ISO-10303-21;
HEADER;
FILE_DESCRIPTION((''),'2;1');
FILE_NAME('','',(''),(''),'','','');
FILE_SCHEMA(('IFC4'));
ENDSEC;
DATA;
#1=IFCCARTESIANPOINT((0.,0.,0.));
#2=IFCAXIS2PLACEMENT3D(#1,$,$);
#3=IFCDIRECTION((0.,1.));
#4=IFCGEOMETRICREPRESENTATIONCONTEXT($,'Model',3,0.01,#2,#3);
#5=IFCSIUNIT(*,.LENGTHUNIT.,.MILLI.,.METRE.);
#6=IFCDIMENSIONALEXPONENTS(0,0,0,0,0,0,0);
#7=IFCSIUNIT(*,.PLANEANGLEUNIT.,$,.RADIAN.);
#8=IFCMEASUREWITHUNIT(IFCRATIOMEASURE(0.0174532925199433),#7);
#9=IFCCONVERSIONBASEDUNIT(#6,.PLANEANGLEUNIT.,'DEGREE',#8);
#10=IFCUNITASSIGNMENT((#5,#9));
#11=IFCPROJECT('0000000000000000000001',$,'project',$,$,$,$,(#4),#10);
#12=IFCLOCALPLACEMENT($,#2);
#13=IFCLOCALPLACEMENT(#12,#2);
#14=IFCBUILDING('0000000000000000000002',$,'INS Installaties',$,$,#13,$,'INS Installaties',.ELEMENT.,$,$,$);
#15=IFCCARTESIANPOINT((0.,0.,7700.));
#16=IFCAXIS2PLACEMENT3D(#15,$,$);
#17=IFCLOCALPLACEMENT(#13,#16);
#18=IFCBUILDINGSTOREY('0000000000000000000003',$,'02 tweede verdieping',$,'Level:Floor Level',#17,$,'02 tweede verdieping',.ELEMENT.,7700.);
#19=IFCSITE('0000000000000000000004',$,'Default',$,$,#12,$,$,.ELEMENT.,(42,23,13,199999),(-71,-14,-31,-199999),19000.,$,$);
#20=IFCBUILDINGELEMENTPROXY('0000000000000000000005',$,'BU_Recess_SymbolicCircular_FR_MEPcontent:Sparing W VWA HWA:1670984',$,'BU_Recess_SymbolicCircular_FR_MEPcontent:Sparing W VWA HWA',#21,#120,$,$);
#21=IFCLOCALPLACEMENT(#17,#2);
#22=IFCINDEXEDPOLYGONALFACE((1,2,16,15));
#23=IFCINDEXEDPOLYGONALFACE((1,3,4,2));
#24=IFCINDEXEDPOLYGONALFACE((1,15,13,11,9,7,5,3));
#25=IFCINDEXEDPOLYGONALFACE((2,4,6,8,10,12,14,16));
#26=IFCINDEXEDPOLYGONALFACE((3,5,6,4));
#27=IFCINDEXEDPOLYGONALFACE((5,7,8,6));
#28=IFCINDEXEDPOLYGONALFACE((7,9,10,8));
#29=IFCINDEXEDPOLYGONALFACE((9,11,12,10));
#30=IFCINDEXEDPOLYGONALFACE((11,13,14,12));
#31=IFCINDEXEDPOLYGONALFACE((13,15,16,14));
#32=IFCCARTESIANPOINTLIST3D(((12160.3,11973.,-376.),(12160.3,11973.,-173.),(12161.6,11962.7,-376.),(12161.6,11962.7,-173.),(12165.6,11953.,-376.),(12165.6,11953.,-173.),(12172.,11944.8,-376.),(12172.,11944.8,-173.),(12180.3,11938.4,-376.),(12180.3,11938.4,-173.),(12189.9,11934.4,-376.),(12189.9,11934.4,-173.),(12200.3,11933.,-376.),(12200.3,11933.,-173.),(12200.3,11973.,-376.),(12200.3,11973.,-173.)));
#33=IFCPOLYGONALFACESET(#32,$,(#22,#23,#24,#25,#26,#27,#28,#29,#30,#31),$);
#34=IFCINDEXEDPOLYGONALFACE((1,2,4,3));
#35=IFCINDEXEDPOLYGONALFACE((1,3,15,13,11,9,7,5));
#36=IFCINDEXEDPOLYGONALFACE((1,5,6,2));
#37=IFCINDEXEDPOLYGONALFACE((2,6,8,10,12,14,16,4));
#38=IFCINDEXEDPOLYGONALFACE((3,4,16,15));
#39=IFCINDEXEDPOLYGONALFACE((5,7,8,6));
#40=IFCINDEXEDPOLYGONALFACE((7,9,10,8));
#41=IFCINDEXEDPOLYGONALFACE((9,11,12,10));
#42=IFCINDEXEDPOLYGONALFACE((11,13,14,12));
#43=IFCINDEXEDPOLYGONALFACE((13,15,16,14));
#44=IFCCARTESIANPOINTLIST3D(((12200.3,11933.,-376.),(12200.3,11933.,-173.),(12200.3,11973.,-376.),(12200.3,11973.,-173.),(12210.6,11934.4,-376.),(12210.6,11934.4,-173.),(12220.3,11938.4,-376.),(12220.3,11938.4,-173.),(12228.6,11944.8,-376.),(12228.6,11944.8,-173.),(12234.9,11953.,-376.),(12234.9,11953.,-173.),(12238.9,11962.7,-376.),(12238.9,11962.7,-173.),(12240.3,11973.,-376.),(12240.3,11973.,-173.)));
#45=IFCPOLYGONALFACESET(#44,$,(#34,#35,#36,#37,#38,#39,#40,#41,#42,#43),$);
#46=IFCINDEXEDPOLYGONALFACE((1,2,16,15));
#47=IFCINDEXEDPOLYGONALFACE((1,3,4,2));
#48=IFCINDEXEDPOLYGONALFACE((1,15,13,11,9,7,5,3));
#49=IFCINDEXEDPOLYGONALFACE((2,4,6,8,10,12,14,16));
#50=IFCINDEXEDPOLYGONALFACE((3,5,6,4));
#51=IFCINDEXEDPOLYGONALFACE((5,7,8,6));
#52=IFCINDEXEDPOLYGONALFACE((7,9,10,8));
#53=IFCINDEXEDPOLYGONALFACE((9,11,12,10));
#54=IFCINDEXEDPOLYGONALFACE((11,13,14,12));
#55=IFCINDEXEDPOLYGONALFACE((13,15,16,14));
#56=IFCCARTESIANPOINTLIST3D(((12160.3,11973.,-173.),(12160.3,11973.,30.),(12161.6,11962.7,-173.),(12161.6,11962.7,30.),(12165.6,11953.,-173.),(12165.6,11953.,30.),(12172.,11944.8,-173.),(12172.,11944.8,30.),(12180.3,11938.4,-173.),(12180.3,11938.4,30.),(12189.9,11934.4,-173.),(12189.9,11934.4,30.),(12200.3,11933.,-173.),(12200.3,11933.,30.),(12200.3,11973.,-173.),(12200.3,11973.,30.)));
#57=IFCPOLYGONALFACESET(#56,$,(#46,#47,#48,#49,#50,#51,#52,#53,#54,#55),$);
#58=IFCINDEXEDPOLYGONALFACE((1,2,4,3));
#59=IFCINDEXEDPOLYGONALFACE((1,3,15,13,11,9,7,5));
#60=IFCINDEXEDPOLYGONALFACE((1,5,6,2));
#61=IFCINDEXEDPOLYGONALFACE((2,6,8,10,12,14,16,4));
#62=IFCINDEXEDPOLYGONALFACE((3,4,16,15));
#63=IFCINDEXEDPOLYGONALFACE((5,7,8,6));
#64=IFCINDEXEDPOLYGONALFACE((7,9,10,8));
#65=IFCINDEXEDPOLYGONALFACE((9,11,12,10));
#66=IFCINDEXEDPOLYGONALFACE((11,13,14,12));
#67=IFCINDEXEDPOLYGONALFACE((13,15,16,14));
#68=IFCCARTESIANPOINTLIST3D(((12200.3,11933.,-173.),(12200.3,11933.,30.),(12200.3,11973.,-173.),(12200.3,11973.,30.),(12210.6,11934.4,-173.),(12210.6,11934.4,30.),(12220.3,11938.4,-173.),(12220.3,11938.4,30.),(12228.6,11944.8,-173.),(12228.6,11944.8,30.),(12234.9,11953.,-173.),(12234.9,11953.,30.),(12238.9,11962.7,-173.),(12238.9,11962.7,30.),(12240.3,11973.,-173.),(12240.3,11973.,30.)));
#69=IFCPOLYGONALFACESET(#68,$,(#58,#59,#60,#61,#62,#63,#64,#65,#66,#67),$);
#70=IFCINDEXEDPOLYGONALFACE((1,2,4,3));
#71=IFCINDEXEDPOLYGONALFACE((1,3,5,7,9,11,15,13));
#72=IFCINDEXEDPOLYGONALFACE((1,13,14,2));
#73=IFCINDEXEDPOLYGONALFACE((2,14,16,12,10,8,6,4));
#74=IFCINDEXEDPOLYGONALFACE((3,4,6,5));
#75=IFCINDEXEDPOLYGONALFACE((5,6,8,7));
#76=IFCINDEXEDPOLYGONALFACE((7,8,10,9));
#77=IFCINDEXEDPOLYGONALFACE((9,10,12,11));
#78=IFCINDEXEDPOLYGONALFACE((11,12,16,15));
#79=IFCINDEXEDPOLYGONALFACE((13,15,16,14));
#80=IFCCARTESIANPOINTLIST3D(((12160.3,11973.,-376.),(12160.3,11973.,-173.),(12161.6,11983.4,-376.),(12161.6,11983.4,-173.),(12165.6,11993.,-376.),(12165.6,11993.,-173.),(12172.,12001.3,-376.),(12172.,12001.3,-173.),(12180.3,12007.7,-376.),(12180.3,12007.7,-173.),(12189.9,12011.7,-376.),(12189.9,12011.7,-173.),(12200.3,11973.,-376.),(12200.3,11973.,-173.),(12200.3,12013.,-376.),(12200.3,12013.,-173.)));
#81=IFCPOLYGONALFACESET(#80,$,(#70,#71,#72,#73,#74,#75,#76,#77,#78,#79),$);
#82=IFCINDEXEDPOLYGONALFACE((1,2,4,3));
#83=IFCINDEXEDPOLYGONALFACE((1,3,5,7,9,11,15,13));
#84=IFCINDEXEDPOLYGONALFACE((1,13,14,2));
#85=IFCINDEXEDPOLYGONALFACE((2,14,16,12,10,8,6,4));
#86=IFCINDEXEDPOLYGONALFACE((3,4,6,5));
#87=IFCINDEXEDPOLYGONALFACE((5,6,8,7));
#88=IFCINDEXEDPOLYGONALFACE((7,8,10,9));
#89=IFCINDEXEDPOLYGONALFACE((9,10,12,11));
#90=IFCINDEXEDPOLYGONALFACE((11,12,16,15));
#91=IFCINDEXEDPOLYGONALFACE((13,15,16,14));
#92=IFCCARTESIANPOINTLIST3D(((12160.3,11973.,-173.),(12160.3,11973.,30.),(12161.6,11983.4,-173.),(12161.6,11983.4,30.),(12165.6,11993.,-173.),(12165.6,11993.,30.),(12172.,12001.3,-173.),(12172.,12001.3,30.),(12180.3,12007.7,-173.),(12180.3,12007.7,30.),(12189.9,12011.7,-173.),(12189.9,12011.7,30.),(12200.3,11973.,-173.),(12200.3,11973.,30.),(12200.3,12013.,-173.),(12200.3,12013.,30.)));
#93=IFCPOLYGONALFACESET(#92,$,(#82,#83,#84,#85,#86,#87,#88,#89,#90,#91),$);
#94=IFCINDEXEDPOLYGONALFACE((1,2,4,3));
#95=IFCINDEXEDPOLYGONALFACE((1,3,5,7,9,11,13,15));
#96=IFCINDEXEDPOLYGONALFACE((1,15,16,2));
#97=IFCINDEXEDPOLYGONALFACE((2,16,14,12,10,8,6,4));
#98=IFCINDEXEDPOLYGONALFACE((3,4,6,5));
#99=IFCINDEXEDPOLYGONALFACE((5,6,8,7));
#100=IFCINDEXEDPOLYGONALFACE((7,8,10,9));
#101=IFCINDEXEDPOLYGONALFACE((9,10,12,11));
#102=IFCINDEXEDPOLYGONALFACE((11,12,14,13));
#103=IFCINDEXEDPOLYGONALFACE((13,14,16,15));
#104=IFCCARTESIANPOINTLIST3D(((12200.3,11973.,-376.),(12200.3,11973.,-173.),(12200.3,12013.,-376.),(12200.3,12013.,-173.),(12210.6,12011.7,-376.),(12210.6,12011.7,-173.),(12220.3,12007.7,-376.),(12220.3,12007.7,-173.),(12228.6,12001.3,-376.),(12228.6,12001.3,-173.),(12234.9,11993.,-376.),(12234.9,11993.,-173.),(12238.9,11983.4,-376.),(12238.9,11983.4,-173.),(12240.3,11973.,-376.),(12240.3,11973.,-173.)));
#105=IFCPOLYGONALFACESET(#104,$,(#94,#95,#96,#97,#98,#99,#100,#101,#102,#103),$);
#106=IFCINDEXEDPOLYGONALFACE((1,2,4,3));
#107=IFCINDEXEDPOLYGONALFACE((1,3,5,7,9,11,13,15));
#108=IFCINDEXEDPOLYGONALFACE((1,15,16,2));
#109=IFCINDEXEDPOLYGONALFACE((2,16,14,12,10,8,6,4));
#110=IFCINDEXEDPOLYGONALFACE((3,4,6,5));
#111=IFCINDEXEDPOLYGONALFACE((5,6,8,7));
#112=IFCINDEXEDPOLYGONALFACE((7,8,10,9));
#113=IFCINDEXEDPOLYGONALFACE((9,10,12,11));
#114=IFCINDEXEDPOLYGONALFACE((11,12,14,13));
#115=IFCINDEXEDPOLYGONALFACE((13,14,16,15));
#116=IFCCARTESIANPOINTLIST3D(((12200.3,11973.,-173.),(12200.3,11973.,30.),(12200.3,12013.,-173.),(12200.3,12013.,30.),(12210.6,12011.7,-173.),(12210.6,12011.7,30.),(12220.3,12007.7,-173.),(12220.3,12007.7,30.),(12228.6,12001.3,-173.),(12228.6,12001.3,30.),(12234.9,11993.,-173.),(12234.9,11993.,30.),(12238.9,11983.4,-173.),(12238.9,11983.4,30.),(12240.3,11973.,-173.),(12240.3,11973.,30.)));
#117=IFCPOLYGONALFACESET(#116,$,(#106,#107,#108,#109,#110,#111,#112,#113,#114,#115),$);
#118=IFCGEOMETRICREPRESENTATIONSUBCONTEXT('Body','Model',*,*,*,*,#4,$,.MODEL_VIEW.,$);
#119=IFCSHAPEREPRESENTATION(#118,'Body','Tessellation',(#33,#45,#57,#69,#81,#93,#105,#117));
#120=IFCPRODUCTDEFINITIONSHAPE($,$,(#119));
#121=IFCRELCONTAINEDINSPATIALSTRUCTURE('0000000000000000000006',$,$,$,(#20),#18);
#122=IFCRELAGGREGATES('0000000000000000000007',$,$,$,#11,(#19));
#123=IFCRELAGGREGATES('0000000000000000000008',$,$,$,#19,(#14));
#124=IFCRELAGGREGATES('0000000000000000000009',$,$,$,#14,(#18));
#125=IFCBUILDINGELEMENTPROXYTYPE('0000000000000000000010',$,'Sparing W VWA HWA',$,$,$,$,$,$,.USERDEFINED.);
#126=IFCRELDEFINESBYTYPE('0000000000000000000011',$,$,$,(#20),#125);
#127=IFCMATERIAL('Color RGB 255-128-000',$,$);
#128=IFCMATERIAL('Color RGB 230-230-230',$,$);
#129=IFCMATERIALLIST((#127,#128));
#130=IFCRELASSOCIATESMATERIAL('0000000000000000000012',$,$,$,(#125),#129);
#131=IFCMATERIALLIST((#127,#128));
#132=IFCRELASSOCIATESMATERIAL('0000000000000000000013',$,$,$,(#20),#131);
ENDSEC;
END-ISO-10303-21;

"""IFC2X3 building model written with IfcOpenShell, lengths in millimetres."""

from ifc_helpers import new_model, entity, si_unit, converted_unit, direction, frame, frame_2d, origin, place, context, subcontext, project, spatial, polyline, circle_curve, parameter, trimmed, segment, composite_curve, outline, extrude, source, transform, mapped, material, material_list, type_object, type_shapes, element, save


model = new_model("IFC2X3")

# Units and contexts
model_context = context("Model", 3, precision=0.01, world=origin(), true_north=direction((0.0, 1.0)))
body_context = subcontext(model_context, "Body", "Model", "MODEL_VIEW")
ifc_project = project(units=[si_unit("LENGTHUNIT", "METRE", prefix="MILLI"), converted_unit("PLANEANGLEUNIT", "DEGREE", entity("IfcRatioMeasure", 0.0174532925199433), si_unit("PLANEANGLEUNIT", "RADIAN"), dimensions=[0, 0, 0, 0, 0, 0, 0])], contexts=[model_context])

# Site, building, storey
site_placement = place(None, origin())
site = spatial("IfcSite", under=ifc_project, at=site_placement, Name="Default", CompositionType="ELEMENT", RefLatitude=(42, 23, 13, 199999), RefLongitude=(-71, -14, -31, -199999), RefElevation=19000.0)
building_placement = place(site_placement, origin())
building = spatial("IfcBuilding", under=site, at=building_placement, Name="INS Installaties", LongName="INS Installaties", CompositionType="ELEMENT")
storey_placement = place(building_placement, frame((0.0, 0.0, 7700.0)))
storey = spatial("IfcBuildingStorey", under=building, at=storey_placement, Name="02 tweede verdieping", ObjectType="Level:Floor Level", LongName="02 tweede verdieping", CompositionType="ELEMENT", Elevation=7700.0)

# Building element proxy
ifc_material_1 = material(Name="Color RGB 255-128-000")
ifc_material_2 = material(Name="Color RGB 230-230-230")
ifc_material_list_1 = material_list([ifc_material_1, ifc_material_2])
building_element_proxy_type_1 = type_object("IfcBuildingElementProxyType", Name="Sparing W VWA HWA", PredefinedType="USERDEFINED", material=ifc_material_list_1)
shared_shape_1 = source(origin(), body_context, "Body", "SweptSolid", [
    extrude(outline(composite_curve([segment(trimmed(circle_curve(frame_2d((13.3, 13.3), x_axis=(1.0, 0.0)), 40.0), [parameter(180.0)], [parameter(270.0)], True, "PARAMETER"), True, "CONTINUOUS"), segment(polyline([(13.3, -26.7), (13.3, 13.3)]), True, "CONTINUOUS"), segment(polyline([(13.3, 13.3), (-26.7, 13.3)]), True, "CONTINUOUS")], self_intersect=False)), frame((13.3, 13.3, -403.0), z_axis=(0.0, 0.0, 1.0), x_axis=(-1.0, 0.0, 0.0)), (0.0, 0.0, 1.0), 203.0),
    extrude(outline(composite_curve([segment(polyline([(-26.7, -13.3), (13.3, -13.3)]), True, "CONTINUOUS"), segment(polyline([(13.3, -13.3), (13.3, 26.7)]), True, "CONTINUOUS"), segment(trimmed(circle_curve(frame_2d((13.3, -13.3), x_axis=(1.0, 0.0)), 40.0), [parameter(90.0)], [parameter(180.0)], True, "PARAMETER"), True, "CONTINUOUS")], self_intersect=False)), frame((-13.3, 13.3, -403.0)), (0.0, 0.0, 1.0), 203.0),
    extrude(outline(composite_curve([segment(trimmed(circle_curve(frame_2d((13.3, 13.3), x_axis=(1.0, 0.0)), 40.0), [parameter(180.0)], [parameter(270.0)], True, "PARAMETER"), True, "CONTINUOUS"), segment(polyline([(13.3, -26.7), (13.3, 13.3)]), True, "CONTINUOUS"), segment(polyline([(13.3, 13.3), (-26.7, 13.3)]), True, "CONTINUOUS")], self_intersect=False)), frame((13.3, 13.3, -200.0), z_axis=(0.0, 0.0, 1.0), x_axis=(-1.0, 0.0, 0.0)), (0.0, 0.0, 1.0), 203.0),
    extrude(outline(composite_curve([segment(polyline([(-26.7, -13.3), (13.3, -13.3)]), True, "CONTINUOUS"), segment(polyline([(13.3, -13.3), (13.3, 26.7)]), True, "CONTINUOUS"), segment(trimmed(circle_curve(frame_2d((13.3, -13.3), x_axis=(1.0, 0.0)), 40.0), [parameter(90.0)], [parameter(180.0)], True, "PARAMETER"), True, "CONTINUOUS")], self_intersect=False)), frame((-13.3, 13.3, -200.0)), (0.0, 0.0, 1.0), 203.0),
    extrude(outline(composite_curve([segment(polyline([(-26.7, -13.3), (13.3, -13.3)]), True, "CONTINUOUS"), segment(polyline([(13.3, -13.3), (13.3, 26.7)]), True, "CONTINUOUS"), segment(trimmed(circle_curve(frame_2d((13.3, -13.3), x_axis=(1.0, 0.0)), 40.0), [parameter(90.0)], [parameter(180.0)], True, "PARAMETER"), True, "CONTINUOUS")], self_intersect=False)), frame((13.3, -13.3, -403.0), z_axis=(0.0, 0.0, 1.0), x_axis=(-1.0, 0.0, 0.0)), (0.0, 0.0, 1.0), 203.0),
    extrude(outline(composite_curve([segment(polyline([(-26.7, -13.3), (13.3, -13.3)]), True, "CONTINUOUS"), segment(polyline([(13.3, -13.3), (13.3, 26.7)]), True, "CONTINUOUS"), segment(trimmed(circle_curve(frame_2d((13.3, -13.3), x_axis=(1.0, 0.0)), 40.0), [parameter(90.0)], [parameter(180.0)], True, "PARAMETER"), True, "CONTINUOUS")], self_intersect=False)), frame((13.3, -13.3, -200.0), z_axis=(0.0, 0.0, 1.0), x_axis=(-1.0, 0.0, 0.0)), (0.0, 0.0, 1.0), 203.0),
    extrude(outline(composite_curve([segment(trimmed(circle_curve(frame_2d((13.3, 13.3), x_axis=(1.0, 0.0)), 40.0), [parameter(180.0)], [parameter(270.0)], True, "PARAMETER"), True, "CONTINUOUS"), segment(polyline([(13.3, -26.7), (13.3, 13.3)]), True, "CONTINUOUS"), segment(polyline([(13.3, 13.3), (-26.7, 13.3)]), True, "CONTINUOUS")], self_intersect=False)), frame((-13.3, -13.3, -403.0)), (0.0, 0.0, 1.0), 203.0),
    extrude(outline(composite_curve([segment(trimmed(circle_curve(frame_2d((13.3, 13.3), x_axis=(1.0, 0.0)), 40.0), [parameter(180.0)], [parameter(270.0)], True, "PARAMETER"), True, "CONTINUOUS"), segment(polyline([(13.3, -26.7), (13.3, 13.3)]), True, "CONTINUOUS"), segment(polyline([(13.3, 13.3), (-26.7, 13.3)]), True, "CONTINUOUS")], self_intersect=False)), frame((-13.3, -13.3, -200.0)), (0.0, 0.0, 1.0), 203.0),
])
type_shapes(building_element_proxy_type_1, [shared_shape_1])
ifc_material_list_2 = material_list([ifc_material_1, ifc_material_2])
proxy_1_placement = place(storey_placement, frame((12200.3, 11973.0, 27.0), z_axis=(0.0, 0.0, 1.0), x_axis=(-1.0, 0.0, 0.0)))
element("IfcBuildingElementProxy", 1, at=proxy_1_placement, inside=storey, type_object=building_element_proxy_type_1, material=ifc_material_list_2, Name="BU_Recess_SymbolicCircular_FR_MEPcontent:Sparing W VWA HWA:1670984", ObjectType="BU_Recess_SymbolicCircular_FR_MEPcontent:Sparing W VWA HWA", context=body_context, shape_type="MappedRepresentation", body=[
    mapped(shared_shape_1, transform((0.0, 0.0, 0.0), scale=1.0)),
])

save(model, "model.ifc")
